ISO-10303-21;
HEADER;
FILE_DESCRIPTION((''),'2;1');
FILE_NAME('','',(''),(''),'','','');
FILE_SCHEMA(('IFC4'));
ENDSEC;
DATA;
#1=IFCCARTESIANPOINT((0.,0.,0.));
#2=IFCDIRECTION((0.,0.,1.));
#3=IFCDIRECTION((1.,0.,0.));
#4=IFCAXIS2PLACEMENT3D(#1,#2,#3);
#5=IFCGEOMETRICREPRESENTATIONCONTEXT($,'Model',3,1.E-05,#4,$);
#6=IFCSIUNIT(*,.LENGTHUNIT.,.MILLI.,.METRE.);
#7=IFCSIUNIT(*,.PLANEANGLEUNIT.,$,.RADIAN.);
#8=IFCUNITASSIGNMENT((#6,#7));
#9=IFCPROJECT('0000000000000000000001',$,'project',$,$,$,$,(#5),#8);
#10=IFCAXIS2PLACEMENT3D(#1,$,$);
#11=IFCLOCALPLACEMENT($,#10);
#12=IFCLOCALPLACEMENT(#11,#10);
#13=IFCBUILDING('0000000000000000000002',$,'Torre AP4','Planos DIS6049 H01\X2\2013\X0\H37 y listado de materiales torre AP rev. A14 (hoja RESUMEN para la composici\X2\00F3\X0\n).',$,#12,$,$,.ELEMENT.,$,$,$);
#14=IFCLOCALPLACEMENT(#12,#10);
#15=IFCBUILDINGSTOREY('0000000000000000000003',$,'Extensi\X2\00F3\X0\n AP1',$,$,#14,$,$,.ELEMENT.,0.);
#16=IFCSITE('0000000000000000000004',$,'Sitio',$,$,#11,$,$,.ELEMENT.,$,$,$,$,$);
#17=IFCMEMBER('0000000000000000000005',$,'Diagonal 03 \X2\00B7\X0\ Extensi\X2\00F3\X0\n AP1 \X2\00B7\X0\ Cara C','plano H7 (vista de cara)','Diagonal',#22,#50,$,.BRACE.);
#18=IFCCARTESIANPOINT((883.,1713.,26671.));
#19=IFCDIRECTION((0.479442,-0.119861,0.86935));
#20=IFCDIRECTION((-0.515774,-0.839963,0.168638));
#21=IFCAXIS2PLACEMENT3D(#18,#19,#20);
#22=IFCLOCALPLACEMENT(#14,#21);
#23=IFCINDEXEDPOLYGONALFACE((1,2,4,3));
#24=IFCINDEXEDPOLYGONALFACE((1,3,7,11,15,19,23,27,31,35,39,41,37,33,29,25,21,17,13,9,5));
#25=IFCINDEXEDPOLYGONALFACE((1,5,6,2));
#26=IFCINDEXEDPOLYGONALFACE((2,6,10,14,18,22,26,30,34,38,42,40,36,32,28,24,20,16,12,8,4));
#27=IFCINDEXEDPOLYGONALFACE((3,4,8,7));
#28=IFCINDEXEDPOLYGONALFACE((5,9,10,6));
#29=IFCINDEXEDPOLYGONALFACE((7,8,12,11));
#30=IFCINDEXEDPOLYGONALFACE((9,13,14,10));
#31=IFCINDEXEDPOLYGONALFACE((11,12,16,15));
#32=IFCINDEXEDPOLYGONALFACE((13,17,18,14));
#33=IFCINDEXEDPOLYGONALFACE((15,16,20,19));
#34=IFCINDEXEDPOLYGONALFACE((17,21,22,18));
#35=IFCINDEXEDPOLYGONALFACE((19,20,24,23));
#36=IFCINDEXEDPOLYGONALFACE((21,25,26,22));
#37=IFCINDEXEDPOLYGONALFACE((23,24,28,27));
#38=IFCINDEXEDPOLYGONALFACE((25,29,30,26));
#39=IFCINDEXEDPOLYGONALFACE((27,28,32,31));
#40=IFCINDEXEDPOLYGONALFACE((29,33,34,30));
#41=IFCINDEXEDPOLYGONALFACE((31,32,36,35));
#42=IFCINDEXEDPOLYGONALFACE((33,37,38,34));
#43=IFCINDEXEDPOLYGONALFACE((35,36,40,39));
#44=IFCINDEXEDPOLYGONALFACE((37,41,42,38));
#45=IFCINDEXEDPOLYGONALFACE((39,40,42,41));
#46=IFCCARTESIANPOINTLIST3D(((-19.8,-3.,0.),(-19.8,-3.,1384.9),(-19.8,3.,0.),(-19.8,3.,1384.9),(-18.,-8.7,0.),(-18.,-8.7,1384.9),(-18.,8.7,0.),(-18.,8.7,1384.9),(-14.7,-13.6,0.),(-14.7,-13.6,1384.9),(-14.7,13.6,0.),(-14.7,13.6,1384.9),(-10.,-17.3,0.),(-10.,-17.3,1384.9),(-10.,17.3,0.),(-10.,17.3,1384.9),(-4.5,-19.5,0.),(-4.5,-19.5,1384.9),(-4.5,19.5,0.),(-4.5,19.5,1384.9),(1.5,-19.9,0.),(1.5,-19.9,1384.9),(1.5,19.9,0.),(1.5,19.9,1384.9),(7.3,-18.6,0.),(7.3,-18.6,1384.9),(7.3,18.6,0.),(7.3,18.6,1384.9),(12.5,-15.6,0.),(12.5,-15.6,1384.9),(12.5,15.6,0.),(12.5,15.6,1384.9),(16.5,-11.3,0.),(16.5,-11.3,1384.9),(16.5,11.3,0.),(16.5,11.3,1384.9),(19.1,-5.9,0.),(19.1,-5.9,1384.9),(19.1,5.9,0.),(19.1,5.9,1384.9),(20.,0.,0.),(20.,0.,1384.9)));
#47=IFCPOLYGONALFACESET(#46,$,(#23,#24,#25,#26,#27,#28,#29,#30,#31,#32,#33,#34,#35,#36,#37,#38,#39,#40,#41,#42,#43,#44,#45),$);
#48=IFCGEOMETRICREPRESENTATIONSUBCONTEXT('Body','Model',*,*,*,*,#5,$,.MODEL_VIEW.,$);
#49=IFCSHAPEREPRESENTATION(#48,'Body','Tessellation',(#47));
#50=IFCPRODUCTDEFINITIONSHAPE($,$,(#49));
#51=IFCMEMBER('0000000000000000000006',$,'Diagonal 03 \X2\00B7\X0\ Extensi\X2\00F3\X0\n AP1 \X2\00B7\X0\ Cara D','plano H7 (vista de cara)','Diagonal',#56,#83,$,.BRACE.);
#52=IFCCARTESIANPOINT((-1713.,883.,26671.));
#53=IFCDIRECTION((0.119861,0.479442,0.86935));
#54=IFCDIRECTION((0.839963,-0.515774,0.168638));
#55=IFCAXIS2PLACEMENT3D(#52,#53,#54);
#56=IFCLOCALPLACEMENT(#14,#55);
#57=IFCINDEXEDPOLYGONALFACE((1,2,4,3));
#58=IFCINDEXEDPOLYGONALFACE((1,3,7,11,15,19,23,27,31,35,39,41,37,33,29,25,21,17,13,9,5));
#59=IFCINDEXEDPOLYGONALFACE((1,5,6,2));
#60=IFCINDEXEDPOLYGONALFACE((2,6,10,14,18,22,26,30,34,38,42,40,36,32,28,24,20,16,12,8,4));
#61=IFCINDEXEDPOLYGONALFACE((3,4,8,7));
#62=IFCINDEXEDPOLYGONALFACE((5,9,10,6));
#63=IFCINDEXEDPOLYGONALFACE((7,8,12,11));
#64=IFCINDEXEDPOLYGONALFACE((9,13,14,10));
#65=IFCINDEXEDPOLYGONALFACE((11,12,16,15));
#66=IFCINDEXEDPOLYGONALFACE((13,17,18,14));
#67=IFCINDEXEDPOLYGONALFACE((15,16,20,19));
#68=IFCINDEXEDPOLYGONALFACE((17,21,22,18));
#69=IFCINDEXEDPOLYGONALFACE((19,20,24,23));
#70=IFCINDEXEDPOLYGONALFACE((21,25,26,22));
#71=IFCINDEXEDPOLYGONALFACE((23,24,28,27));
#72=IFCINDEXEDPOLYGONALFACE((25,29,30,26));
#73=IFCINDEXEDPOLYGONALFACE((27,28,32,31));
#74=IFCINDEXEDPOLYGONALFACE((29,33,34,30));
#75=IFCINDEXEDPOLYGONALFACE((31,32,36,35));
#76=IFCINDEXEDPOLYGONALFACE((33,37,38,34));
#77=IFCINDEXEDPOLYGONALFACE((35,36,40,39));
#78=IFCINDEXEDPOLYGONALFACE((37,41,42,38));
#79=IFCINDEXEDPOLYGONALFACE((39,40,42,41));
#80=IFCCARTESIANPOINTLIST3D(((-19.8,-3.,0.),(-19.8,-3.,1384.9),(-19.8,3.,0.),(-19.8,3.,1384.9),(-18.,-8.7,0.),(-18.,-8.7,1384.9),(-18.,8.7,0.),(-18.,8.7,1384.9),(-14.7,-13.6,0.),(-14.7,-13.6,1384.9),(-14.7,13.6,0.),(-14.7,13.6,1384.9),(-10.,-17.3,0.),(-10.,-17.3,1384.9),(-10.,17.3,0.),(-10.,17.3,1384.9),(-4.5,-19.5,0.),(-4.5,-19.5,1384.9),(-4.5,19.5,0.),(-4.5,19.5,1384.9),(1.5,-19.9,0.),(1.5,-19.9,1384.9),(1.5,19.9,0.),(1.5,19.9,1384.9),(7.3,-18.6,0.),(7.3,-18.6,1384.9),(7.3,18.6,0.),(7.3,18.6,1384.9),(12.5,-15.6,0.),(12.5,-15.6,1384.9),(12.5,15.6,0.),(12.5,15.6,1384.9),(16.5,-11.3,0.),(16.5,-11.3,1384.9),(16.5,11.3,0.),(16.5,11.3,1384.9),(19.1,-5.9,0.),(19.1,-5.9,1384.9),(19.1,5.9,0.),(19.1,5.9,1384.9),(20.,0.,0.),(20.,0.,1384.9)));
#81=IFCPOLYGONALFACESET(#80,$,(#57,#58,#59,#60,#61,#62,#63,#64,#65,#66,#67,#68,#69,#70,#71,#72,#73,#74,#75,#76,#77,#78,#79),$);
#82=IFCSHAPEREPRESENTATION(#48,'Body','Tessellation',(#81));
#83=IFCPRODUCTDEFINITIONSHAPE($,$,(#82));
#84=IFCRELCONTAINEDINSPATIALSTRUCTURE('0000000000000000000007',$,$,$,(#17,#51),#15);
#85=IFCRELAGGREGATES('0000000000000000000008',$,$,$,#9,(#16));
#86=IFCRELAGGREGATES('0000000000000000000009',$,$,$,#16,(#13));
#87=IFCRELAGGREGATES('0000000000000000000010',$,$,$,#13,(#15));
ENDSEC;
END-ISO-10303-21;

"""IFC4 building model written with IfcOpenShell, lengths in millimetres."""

from ifc_helpers import new_model, si_unit, frame, origin, origin_with_axes, place, context, subcontext, project, spatial, circle, extrude, element, save


model = new_model("IFC4")

# Units and contexts
model_context = context("Model", 3, precision=1e-05, world=origin_with_axes())
body_context = subcontext(model_context, "Body", "Model", "MODEL_VIEW")
ifc_project = project(units=[si_unit("LENGTHUNIT", "METRE", prefix="MILLI"), si_unit("PLANEANGLEUNIT", "RADIAN")], contexts=[model_context])

# Site, building, storey
site_placement = place(None, origin())
site = spatial("IfcSite", under=ifc_project, at=site_placement, Name="Sitio", CompositionType="ELEMENT")
building_placement = place(site_placement, origin())
building = spatial("IfcBuilding", under=site, at=building_placement, Name="Torre AP4", Description="Planos DIS6049 H01–H37 y listado de materiales torre AP rev. A14 (hoja RESUMEN para la composición).", CompositionType="ELEMENT")
storey_placement = place(building_placement, origin())
storey = spatial("IfcBuildingStorey", under=building, at=storey_placement, Name="Extensión AP1", CompositionType="ELEMENT", Elevation=0.0)

# Members
for number, where, z_axis, x_axis, name in (
    (1, (883.0, 1713.0, 26671.0), (0.479442, -0.119861, 0.86935), (-0.515774, -0.839963, 0.168638), "Diagonal 03 · Extensión AP1 · Cara C"),
    (2, (-1713.0, 883.0, 26671.0), (0.119861, 0.479442, 0.86935), (0.839963, -0.515774, 0.168638), "Diagonal 03 · Extensión AP1 · Cara D"),
):
    element("IfcMember", number, at=place(storey_placement, frame(where, z_axis=z_axis, x_axis=x_axis)), inside=storey, Name=name, Description="plano H7 (vista de cara)", ObjectType="Diagonal", PredefinedType="BRACE", context=body_context, shape_type="SweptSolid", body=[
        extrude(circle(Radius=20.0), None, (0.0, 0.0, 1.0), 1384.9),
    ])

save(model, "model.ifc")
